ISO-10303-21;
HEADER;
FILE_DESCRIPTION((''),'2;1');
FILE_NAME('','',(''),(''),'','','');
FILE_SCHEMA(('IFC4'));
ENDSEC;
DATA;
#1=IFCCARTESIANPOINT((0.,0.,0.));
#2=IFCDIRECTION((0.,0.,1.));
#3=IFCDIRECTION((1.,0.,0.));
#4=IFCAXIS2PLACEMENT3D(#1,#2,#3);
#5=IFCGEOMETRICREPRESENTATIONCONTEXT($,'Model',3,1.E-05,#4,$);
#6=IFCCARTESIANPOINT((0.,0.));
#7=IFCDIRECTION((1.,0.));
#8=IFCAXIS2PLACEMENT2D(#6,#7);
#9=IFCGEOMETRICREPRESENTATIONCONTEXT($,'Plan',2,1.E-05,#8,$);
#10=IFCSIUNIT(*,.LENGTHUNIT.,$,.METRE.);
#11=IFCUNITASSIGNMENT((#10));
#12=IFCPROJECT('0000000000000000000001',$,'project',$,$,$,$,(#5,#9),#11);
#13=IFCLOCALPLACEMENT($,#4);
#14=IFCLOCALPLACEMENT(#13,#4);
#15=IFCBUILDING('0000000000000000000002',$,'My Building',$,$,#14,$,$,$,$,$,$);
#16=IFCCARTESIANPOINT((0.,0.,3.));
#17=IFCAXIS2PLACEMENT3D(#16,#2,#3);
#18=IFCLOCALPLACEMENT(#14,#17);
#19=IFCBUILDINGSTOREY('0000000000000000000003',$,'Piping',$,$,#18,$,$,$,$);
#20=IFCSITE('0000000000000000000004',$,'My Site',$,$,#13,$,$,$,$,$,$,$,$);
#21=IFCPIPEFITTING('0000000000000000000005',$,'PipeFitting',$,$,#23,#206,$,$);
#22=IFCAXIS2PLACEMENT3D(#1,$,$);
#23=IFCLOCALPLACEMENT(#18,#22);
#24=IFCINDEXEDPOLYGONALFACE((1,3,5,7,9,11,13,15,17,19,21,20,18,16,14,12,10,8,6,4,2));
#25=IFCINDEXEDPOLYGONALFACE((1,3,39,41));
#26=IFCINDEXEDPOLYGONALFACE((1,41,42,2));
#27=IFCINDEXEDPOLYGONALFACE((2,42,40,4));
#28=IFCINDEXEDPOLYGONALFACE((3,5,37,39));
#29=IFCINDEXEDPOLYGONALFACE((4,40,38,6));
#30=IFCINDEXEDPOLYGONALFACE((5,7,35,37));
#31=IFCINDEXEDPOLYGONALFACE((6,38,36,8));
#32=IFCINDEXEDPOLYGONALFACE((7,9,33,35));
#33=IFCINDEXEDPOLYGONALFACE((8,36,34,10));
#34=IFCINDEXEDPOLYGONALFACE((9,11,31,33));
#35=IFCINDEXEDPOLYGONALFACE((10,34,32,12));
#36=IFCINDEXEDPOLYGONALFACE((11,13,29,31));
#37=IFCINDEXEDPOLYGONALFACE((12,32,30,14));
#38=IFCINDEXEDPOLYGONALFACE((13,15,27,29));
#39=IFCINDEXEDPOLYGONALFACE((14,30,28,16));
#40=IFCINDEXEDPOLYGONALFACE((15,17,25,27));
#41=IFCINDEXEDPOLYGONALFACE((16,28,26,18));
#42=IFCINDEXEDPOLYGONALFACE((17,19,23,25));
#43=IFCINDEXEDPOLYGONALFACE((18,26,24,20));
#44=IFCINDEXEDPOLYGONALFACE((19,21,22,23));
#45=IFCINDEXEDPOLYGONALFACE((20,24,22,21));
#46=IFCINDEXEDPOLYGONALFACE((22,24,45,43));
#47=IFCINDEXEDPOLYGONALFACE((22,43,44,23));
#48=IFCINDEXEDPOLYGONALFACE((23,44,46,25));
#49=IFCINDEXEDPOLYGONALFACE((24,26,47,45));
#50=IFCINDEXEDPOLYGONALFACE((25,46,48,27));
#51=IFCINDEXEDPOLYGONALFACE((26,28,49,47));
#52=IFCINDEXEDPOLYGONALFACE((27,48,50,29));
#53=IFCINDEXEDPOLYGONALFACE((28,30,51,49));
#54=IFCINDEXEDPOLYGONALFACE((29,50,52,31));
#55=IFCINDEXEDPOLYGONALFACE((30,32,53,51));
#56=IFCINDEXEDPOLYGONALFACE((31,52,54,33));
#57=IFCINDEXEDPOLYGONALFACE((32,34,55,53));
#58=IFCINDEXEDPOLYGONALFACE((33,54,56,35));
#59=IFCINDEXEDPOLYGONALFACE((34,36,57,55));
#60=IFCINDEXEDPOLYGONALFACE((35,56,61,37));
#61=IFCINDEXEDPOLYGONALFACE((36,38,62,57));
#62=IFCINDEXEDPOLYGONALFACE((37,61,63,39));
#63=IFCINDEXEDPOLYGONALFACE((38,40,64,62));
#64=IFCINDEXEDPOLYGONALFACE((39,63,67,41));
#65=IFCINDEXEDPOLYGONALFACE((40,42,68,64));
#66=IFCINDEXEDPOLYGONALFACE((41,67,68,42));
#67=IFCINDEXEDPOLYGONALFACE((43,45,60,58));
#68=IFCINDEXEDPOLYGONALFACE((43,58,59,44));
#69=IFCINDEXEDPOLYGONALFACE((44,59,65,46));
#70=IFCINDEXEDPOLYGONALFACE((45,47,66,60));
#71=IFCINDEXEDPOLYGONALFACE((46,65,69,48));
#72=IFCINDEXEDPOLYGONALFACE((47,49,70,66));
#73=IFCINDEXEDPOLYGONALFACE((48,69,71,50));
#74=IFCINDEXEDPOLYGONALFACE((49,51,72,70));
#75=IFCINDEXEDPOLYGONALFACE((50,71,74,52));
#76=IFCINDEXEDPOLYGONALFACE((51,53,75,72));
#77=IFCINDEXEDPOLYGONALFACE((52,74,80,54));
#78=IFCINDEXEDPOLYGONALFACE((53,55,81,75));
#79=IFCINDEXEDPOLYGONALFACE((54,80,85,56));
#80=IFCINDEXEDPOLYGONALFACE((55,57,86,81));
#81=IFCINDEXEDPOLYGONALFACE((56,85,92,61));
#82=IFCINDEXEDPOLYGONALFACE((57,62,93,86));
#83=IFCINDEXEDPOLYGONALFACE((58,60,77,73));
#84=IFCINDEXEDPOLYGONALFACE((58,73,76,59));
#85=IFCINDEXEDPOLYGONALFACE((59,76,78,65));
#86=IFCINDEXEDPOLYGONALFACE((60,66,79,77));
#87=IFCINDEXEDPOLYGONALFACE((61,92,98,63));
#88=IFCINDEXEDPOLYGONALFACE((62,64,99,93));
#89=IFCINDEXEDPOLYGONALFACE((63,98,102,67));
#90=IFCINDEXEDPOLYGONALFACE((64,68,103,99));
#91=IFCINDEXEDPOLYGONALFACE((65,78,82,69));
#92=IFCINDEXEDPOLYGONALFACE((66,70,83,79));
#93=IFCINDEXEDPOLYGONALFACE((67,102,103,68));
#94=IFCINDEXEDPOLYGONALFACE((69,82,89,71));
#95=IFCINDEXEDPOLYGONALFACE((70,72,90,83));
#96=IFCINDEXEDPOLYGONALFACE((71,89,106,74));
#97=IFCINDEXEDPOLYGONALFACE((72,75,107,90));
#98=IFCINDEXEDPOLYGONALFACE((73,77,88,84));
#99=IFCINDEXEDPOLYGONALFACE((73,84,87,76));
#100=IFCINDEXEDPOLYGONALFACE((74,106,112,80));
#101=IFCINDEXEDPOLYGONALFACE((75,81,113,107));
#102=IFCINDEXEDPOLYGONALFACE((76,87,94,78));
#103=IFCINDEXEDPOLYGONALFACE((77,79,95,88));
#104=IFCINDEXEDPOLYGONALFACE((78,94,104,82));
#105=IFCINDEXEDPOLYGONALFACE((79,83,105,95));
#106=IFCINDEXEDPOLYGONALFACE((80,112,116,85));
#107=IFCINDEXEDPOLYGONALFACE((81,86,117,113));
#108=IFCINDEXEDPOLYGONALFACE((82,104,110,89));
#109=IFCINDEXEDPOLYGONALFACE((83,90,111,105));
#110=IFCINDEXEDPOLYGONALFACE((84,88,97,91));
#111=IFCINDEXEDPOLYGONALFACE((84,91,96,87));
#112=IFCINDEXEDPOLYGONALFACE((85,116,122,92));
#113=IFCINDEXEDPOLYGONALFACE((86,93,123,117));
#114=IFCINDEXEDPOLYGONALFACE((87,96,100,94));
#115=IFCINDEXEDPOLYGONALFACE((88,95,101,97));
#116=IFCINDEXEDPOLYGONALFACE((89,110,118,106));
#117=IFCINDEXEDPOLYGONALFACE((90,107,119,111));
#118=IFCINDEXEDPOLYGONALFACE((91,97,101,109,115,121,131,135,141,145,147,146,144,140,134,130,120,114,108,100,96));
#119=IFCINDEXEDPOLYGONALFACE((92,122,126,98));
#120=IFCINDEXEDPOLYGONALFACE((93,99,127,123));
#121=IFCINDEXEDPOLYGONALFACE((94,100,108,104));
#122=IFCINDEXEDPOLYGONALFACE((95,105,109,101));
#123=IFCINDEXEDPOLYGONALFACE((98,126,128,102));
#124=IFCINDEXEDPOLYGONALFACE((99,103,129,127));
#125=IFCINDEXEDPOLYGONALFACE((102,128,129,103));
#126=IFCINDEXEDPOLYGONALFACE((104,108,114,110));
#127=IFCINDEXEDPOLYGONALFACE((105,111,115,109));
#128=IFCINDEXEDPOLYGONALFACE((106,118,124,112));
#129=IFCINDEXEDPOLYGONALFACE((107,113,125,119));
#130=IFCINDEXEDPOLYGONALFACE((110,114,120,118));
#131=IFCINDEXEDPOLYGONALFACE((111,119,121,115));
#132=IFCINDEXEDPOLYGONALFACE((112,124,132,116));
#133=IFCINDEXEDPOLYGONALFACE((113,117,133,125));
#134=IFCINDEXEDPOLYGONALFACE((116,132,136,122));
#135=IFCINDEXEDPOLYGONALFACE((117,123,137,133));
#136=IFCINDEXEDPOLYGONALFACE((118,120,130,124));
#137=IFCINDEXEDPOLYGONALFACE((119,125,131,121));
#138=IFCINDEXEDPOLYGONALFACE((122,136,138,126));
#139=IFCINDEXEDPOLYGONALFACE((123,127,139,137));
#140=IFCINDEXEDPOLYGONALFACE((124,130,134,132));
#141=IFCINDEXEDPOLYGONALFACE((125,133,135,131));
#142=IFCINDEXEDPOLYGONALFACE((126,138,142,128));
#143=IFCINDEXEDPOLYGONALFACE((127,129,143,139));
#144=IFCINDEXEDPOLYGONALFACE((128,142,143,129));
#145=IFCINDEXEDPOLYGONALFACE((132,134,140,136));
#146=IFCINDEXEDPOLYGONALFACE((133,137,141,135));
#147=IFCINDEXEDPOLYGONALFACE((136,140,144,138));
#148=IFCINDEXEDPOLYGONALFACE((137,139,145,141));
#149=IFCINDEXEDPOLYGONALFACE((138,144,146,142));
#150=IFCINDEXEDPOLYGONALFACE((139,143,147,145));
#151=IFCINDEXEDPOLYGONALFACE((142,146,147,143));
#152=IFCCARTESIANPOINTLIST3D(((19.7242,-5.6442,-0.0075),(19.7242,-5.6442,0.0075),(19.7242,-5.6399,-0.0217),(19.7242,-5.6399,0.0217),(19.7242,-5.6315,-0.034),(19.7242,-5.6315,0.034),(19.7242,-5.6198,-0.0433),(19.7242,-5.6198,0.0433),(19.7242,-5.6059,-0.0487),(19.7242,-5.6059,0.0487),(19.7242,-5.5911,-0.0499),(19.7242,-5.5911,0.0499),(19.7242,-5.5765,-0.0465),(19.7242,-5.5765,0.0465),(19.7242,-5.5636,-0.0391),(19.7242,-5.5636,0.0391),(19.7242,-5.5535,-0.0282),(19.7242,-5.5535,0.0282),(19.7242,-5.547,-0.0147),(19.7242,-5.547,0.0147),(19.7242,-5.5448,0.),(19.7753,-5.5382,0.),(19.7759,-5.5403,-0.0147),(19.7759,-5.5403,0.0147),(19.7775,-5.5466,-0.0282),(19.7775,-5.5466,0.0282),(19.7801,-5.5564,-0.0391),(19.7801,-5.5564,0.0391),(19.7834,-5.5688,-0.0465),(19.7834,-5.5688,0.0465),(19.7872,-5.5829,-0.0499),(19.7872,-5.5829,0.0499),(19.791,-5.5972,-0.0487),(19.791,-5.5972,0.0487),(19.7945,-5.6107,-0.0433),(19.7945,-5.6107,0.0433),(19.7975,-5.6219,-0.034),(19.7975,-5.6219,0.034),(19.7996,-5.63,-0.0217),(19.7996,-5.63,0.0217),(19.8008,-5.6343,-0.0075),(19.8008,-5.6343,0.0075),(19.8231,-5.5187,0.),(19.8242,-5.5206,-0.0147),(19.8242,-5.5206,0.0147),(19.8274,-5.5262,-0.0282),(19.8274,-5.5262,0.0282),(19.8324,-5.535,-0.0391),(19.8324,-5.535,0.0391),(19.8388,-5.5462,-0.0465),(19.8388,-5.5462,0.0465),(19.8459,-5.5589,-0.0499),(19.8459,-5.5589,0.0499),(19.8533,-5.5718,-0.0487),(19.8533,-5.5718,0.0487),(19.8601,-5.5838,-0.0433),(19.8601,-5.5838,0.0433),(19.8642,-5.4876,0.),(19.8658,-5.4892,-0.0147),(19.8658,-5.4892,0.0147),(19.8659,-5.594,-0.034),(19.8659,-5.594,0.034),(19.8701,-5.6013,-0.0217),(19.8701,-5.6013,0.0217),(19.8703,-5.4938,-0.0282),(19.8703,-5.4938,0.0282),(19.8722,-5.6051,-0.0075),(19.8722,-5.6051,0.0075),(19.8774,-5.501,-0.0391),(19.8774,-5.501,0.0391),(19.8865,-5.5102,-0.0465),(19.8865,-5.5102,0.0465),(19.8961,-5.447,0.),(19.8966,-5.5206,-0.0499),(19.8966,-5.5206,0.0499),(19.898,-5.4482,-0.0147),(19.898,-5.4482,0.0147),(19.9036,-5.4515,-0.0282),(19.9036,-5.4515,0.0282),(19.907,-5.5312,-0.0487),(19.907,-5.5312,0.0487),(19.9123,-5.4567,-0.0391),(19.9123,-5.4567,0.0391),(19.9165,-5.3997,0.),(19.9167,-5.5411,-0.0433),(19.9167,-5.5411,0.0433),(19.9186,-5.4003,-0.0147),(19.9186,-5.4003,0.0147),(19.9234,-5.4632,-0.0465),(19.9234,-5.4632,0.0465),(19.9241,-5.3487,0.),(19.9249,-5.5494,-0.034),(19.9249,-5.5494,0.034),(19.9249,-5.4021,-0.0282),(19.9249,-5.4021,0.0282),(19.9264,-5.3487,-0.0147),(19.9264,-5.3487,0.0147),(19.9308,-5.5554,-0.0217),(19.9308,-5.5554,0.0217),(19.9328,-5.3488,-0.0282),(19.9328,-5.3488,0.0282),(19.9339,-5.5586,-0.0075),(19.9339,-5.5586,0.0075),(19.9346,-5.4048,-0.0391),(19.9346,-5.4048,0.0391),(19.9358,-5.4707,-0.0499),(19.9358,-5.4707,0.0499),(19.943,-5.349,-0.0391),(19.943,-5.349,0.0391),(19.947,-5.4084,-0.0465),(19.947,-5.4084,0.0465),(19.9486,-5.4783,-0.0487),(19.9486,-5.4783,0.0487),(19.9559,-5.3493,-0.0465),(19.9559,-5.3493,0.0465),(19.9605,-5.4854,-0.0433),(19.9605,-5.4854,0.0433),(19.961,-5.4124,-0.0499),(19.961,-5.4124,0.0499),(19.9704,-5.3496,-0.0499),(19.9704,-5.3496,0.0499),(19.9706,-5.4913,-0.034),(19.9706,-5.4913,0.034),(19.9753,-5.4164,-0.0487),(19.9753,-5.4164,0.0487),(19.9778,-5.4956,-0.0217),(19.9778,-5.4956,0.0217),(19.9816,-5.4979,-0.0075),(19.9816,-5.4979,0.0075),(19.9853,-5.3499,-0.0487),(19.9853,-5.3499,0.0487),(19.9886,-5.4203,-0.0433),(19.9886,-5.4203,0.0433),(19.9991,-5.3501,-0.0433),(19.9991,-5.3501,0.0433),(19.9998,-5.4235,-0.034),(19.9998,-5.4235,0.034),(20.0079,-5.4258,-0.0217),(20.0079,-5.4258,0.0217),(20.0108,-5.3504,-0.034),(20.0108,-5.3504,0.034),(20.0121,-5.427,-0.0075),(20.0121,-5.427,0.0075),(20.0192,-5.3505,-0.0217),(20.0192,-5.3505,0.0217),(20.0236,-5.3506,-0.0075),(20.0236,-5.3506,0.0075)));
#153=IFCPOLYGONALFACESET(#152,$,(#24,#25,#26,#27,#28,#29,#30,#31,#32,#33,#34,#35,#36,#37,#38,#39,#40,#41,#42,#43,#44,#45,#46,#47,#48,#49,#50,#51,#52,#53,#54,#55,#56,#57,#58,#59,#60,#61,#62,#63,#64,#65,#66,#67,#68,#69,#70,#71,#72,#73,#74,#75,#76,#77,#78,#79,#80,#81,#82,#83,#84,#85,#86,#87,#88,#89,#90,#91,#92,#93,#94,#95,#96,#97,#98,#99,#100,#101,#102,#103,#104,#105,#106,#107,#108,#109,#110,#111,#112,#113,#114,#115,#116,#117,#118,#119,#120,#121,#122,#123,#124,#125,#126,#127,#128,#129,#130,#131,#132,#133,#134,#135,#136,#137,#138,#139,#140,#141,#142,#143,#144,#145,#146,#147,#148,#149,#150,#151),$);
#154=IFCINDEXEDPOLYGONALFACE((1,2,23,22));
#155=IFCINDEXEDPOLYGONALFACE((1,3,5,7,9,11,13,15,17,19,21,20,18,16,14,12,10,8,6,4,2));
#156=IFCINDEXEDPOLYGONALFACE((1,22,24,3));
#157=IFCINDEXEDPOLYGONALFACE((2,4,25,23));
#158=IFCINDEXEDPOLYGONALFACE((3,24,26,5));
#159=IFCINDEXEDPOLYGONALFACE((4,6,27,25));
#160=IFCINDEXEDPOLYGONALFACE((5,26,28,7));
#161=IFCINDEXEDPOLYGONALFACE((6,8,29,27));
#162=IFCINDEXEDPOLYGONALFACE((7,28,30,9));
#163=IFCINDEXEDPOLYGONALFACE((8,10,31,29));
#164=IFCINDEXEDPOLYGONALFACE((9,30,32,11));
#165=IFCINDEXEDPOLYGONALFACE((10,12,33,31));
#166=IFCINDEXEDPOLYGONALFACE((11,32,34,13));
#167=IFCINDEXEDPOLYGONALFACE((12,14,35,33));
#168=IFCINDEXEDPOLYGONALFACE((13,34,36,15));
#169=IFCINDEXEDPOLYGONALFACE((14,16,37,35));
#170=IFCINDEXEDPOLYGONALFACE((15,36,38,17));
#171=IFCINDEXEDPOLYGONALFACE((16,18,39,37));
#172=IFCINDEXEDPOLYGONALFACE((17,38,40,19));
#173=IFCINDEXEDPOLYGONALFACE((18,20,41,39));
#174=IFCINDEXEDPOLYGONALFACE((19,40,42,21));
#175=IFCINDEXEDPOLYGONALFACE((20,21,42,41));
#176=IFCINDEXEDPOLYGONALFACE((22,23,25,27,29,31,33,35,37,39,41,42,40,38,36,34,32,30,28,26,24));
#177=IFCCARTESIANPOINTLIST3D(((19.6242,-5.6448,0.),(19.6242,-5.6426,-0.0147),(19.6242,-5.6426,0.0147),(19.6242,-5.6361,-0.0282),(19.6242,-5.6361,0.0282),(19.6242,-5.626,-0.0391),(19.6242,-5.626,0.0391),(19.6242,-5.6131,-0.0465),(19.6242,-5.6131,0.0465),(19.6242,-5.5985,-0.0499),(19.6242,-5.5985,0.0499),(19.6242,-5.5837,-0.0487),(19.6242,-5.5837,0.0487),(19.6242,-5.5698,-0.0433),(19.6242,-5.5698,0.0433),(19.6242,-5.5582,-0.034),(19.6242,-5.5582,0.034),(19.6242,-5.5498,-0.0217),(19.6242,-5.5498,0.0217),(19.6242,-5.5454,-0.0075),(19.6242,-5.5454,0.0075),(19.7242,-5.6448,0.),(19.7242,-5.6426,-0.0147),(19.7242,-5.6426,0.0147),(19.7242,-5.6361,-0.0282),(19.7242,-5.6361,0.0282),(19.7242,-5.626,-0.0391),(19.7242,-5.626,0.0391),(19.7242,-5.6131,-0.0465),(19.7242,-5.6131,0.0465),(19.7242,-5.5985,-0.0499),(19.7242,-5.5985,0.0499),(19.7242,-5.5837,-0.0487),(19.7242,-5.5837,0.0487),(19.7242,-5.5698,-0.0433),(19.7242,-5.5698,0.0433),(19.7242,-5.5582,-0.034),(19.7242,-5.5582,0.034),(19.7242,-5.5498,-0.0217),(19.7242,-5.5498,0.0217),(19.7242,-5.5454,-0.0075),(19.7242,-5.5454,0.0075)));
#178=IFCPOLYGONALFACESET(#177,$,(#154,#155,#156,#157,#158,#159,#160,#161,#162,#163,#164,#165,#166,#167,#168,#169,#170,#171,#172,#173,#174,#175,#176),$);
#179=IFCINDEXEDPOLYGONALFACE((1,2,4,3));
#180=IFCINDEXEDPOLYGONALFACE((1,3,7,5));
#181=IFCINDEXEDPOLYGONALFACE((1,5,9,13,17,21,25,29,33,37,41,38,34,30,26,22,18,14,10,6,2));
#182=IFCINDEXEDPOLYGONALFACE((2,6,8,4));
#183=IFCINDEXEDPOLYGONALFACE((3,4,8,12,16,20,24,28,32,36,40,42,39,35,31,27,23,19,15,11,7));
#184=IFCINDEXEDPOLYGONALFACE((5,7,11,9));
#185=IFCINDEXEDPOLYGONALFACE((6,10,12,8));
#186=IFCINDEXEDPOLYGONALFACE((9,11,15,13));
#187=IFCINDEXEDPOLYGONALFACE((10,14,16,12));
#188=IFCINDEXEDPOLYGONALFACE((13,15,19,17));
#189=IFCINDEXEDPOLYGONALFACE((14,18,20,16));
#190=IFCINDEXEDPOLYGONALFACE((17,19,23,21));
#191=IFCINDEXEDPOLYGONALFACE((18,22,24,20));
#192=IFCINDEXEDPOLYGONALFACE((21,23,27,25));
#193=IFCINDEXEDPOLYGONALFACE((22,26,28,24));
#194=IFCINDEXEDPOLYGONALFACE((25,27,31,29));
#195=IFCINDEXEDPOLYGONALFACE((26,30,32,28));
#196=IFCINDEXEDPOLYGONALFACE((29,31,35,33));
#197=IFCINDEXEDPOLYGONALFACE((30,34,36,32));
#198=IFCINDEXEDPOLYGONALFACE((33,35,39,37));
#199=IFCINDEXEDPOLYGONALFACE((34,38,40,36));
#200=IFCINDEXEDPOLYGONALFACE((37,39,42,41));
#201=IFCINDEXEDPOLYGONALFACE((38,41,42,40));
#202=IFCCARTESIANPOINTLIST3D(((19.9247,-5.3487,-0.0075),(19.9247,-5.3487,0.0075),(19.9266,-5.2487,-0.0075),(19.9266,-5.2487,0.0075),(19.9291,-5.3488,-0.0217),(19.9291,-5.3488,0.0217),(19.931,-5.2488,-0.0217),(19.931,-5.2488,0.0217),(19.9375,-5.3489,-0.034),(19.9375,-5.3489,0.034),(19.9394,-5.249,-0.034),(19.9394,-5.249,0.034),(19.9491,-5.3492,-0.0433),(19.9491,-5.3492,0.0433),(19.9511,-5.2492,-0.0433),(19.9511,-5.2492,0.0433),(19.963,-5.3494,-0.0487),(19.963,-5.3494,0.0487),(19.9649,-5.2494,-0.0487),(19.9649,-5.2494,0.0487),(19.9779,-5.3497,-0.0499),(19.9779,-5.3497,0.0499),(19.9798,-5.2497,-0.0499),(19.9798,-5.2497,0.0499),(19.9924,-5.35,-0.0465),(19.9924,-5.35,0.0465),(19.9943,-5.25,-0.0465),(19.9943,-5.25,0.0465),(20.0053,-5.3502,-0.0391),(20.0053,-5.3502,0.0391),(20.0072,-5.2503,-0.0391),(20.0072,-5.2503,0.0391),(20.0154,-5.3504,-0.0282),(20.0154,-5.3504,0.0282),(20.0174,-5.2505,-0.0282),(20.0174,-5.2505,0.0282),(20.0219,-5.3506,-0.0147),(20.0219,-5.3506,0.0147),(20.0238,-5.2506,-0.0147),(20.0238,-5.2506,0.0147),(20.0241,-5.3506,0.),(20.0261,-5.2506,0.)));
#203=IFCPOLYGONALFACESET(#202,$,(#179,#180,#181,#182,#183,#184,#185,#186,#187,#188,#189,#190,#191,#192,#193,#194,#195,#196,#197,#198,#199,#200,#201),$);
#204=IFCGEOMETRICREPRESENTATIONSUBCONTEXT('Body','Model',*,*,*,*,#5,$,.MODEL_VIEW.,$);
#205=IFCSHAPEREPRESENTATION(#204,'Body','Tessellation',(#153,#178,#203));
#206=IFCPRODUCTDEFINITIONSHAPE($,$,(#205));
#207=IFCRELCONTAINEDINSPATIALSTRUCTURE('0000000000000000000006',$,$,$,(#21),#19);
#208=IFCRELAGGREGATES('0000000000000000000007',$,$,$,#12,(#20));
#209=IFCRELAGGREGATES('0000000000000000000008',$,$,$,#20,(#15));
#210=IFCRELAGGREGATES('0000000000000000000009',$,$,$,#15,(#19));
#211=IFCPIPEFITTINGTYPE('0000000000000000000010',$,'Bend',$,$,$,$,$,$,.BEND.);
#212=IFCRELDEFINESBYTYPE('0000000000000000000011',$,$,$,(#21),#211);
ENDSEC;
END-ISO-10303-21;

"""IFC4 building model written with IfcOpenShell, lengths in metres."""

from ifc_helpers import new_model, entity, si_unit, frame, origin_with_axes, origin_2d_with_axis, place, context, subcontext, project, spatial, circle, extrude, source, transform, mapped, type_object, type_shapes, element, save


model = new_model("IFC4")

# Units and contexts
model_context = context("Model", 3, precision=1e-05, world=origin_with_axes())
plan_context = context("Plan", 2, precision=1e-05, world=origin_2d_with_axis())
body_context = subcontext(model_context, "Body", "Model", "MODEL_VIEW")
ifc_project = project(units=[si_unit("LENGTHUNIT", "METRE")], contexts=[model_context, plan_context])

# Site, building, storey
site_placement = place(None, origin_with_axes())
site = spatial("IfcSite", under=ifc_project, at=site_placement, Name="My Site")
building_placement = place(site_placement, origin_with_axes())
building = spatial("IfcBuilding", under=site, at=building_placement, Name="My Building")
storey_placement = place(building_placement, frame((0.0, 0.0, 3.0), z_axis=(0.0, 0.0, 1.0), x_axis=(1.0, 0.0, 0.0)))
storey = spatial("IfcBuildingStorey", under=building, at=storey_placement, Name="Piping")

# Pipe fitting
pipe_fitting_type_1 = type_object("IfcPipeFittingType", Name="Bend", PredefinedType="BEND")
shared_shape_1 = source(origin_with_axes(), body_context, "Body", "SolidModel", [
    entity("IfcSweptDiskSolid", entity("IfcIndexedPolyCurve", entity("IfcCartesianPointList3D", [[0.0, 0.0, -0.1], [-0.0715, 0.0, -0.2751], [-0.2452, 0.0, -0.35]]), [entity("IfcArcIndex", [1, 2, 3])]), 0.05),
    extrude(circle(Radius=0.05), origin_with_axes(), (0.0, 0.0, -1.0), 0.1),
    extrude(circle(Radius=0.05), frame((-0.2452, 0.0, -0.35), z_axis=(-0.999813, 0.0, -0.01935), x_axis=(0.01935, 0.0, -0.999813)), (0.0, 0.0, 1.0), 0.1),
])
type_shapes(pipe_fitting_type_1, [shared_shape_1])
pipe_fitting_1_placement = place(storey_placement, frame((19.6242, -5.5948, 0.0), z_axis=(-1.0, 0.0, 0.0), x_axis=(0.0, -1.0, 0.0)))
element("IfcPipeFitting", 1, at=pipe_fitting_1_placement, inside=storey, type_object=pipe_fitting_type_1, Name="PipeFitting", context=body_context, shape_type="MappedRepresentation", body=[
    mapped(shared_shape_1, transform((0.0, 0.0, 0.0), x_axis=(1.0, 0.0, 0.0), y_axis=(0.0, 1.0, 0.0), z_axis=(0.0, 0.0, 1.0), scale=1.0)),
])

save(model, "model.ifc")
